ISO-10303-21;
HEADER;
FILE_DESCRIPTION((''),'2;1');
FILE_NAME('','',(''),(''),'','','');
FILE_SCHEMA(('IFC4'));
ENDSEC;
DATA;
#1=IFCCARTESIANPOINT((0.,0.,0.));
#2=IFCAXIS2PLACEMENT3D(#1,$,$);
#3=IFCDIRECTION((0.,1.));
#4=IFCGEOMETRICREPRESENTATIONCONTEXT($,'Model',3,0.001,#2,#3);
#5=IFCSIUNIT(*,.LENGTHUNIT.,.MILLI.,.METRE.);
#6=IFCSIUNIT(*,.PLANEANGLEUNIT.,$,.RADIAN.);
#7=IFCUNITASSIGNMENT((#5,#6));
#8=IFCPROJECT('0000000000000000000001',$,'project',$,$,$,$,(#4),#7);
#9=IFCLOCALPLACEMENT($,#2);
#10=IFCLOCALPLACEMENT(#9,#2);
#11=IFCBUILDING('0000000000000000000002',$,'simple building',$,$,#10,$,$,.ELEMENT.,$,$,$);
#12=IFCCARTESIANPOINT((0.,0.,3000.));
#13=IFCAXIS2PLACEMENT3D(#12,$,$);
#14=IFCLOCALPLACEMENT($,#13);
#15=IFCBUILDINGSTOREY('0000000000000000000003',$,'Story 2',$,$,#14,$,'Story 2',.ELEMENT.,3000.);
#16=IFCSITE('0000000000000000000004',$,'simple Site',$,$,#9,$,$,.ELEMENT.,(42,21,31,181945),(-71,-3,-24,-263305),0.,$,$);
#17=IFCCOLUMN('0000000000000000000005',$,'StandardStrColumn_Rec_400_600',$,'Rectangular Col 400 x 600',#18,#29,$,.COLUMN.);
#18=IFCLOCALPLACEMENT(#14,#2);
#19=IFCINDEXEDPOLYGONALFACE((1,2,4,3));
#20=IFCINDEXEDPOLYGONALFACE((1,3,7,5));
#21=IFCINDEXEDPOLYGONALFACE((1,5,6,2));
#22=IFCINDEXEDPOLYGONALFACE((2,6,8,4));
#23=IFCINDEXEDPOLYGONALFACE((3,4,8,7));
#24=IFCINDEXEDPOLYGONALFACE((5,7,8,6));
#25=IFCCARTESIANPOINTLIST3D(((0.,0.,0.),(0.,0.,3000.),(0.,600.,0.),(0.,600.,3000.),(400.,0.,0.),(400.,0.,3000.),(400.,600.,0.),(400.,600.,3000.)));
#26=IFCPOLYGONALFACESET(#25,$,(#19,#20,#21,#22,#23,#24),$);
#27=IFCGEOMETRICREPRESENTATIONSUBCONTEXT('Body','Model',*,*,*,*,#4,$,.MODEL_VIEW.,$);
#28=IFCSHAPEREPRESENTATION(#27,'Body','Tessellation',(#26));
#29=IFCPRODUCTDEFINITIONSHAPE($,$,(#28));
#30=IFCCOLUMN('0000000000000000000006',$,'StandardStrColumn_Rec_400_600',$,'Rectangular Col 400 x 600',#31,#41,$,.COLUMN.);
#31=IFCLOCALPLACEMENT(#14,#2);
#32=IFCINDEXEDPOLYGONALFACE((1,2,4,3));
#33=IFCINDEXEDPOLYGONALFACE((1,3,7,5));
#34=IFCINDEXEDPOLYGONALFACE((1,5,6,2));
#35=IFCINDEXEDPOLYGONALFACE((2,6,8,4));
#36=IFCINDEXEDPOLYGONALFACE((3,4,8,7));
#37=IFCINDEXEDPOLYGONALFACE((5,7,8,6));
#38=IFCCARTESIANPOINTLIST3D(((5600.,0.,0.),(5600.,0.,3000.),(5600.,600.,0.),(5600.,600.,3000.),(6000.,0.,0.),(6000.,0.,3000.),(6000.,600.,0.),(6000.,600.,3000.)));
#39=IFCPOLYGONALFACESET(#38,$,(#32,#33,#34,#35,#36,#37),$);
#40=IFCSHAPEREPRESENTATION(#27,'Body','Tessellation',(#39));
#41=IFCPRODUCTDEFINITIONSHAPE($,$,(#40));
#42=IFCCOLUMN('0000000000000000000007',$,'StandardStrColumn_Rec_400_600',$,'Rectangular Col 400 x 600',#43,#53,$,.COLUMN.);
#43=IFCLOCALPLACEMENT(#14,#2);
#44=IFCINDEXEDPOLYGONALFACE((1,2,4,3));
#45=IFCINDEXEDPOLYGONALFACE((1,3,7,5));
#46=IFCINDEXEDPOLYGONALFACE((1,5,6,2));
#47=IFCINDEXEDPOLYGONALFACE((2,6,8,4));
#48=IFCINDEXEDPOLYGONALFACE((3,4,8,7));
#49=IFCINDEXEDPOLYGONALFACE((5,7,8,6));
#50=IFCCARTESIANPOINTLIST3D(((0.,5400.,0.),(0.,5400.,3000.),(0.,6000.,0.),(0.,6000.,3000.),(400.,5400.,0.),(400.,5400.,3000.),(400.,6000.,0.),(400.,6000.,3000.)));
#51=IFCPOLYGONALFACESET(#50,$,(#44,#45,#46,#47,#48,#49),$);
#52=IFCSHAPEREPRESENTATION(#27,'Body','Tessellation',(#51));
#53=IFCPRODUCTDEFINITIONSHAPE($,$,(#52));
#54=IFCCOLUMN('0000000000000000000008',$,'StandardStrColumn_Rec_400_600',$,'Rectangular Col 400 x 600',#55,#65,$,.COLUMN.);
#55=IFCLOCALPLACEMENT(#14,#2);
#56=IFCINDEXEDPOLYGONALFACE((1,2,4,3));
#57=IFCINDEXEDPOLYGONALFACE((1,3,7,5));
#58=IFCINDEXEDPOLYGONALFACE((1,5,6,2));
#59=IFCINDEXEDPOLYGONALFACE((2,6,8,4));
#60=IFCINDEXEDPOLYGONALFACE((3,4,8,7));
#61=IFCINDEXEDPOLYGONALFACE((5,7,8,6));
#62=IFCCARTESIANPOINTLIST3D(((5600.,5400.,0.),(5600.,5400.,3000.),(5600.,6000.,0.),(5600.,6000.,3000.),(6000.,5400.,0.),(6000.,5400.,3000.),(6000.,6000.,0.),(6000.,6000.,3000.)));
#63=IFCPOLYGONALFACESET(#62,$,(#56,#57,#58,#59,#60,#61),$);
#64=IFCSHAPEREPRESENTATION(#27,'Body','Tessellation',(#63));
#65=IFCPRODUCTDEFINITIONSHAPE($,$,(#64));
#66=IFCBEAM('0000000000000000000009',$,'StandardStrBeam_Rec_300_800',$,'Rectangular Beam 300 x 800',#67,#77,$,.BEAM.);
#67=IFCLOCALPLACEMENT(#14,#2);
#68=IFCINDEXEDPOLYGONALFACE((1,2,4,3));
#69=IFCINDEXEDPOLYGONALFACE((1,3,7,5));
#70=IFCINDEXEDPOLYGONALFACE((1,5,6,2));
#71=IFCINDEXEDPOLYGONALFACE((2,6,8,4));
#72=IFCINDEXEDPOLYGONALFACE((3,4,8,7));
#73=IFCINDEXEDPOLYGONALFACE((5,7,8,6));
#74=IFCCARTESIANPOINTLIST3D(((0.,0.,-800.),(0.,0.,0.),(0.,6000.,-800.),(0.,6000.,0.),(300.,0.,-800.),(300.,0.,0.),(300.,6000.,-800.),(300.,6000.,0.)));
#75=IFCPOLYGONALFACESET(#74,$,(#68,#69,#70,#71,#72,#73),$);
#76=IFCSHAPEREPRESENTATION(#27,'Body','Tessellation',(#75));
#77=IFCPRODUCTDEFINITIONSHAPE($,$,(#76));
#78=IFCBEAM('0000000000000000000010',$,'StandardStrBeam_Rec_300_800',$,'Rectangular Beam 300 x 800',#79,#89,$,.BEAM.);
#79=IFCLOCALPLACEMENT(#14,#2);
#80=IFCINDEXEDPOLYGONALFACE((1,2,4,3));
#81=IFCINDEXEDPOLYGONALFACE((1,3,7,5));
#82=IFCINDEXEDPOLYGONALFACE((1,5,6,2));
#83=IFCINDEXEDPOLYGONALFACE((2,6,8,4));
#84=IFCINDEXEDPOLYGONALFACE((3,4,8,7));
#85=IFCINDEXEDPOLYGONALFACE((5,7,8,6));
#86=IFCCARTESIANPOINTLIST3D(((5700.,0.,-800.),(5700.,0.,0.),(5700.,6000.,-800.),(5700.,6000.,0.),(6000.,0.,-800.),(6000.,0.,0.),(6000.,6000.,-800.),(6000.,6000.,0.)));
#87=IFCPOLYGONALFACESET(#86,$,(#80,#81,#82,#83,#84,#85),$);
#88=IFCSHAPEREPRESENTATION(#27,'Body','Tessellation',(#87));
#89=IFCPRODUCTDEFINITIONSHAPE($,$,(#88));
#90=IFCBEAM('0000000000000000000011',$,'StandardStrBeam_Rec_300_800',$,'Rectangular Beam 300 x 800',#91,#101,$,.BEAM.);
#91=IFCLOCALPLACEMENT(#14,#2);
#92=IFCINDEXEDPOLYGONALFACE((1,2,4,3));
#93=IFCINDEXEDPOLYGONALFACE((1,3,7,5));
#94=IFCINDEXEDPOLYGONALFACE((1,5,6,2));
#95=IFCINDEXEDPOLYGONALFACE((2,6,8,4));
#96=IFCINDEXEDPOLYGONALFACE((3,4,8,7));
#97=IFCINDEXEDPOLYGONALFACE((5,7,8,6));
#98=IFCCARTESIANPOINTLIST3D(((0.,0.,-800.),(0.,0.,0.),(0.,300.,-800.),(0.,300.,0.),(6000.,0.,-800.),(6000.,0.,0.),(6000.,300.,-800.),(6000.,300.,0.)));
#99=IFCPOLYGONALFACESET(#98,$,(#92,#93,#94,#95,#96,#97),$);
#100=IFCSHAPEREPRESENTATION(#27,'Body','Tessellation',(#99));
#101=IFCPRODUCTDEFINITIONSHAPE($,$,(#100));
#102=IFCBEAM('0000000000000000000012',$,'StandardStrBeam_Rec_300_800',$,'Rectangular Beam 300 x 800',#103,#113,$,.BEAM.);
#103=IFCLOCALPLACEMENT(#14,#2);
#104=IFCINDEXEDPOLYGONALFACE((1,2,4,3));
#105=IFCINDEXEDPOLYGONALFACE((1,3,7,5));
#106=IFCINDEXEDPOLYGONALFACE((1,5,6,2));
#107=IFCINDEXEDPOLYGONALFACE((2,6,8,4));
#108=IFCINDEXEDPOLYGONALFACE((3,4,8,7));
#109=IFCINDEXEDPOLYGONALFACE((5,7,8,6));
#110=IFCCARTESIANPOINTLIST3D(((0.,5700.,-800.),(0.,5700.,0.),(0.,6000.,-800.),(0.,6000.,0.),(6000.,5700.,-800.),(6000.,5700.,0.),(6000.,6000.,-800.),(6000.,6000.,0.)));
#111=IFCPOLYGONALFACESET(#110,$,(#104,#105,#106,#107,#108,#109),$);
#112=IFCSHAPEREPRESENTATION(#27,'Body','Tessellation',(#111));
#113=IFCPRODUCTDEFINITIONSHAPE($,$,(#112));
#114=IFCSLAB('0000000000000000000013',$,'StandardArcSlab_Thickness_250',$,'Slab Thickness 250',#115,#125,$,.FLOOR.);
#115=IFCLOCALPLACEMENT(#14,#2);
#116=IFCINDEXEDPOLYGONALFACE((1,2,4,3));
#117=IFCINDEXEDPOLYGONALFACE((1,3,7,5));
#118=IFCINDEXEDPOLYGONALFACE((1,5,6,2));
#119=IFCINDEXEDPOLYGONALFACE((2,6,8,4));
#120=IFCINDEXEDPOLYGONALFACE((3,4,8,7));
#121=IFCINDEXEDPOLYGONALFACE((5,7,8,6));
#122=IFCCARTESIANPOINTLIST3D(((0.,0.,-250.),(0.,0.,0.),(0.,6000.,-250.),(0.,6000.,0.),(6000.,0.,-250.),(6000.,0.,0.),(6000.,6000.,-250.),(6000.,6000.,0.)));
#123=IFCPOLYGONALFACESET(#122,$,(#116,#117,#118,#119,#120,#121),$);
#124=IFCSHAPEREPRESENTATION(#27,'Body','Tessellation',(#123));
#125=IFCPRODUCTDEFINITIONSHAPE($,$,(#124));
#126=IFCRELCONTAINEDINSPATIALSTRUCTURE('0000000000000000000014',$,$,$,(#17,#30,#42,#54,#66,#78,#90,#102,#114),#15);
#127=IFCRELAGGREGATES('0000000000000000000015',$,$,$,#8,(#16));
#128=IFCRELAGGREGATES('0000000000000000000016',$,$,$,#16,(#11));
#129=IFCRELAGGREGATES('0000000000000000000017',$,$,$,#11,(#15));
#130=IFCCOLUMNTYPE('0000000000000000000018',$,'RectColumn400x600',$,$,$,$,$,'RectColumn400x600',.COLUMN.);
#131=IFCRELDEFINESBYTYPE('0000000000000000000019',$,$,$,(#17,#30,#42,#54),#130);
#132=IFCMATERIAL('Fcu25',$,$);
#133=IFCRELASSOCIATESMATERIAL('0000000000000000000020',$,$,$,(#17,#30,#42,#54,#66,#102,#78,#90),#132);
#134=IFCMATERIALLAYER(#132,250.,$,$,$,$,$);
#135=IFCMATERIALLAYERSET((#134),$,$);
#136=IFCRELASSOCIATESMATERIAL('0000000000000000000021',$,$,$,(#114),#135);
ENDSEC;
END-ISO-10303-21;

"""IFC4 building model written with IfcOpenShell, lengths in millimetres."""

from ifc_helpers import new_model, si_unit, direction, frame, origin, origin_with_axes, origin_2d_with_axis, place, context, subcontext, project, spatial, polyline, rectangle, outline, extrude, material, layer, layer_set, layer_usage, material_profile, profile_set, profile_usage, type_object, element, save


model = new_model("IFC4")

# Units and contexts
model_context = context("Model", 3, precision=0.001, world=origin(), true_north=direction((0.0, 1.0)))
body_context = subcontext(model_context, "Body", "Model", "MODEL_VIEW")
ifc_project = project(units=[si_unit("LENGTHUNIT", "METRE", prefix="MILLI"), si_unit("PLANEANGLEUNIT", "RADIAN")], contexts=[model_context])

# Site, building, storey
site_placement = place(None, origin())
site = spatial("IfcSite", under=ifc_project, at=site_placement, Name="simple Site", CompositionType="ELEMENT", RefLatitude=(42, 21, 31, 181945), RefLongitude=(-71, -3, -24, -263305), RefElevation=0.0)
building_placement = place(site_placement, origin())
building = spatial("IfcBuilding", under=site, at=building_placement, Name="simple building", CompositionType="ELEMENT")
storey_placement = place(None, frame((0.0, 0.0, 3000.0)))
storey = spatial("IfcBuildingStorey", under=building, at=storey_placement, Name="Story 2", LongName="Story 2", CompositionType="ELEMENT", Elevation=3000.0)

# Columns
ifc_material = material(Name="Fcu25")
ifc_material_profile_1 = material_profile(ifc_material, rectangle(XDim=400.0, YDim=600.0, at=origin_2d_with_axis()))
ifc_profile_set_1 = profile_set([ifc_material_profile_1])
ifc_profile_usage_1 = profile_usage(ifc_profile_set_1, cardinal=7)
column_type = type_object("IfcColumnType", Name="RectColumn400x600", ElementType="RectColumn400x600", PredefinedType="COLUMN")
column_1_placement = place(None, frame((200.0, 300.0, 3000.0), z_axis=(0.0, 0.0, 1.0), x_axis=(1.0, 0.0, 0.0)))
element("IfcColumn", 1, at=column_1_placement, inside=storey, type_object=column_type, material=ifc_profile_usage_1, Name="StandardStrColumn_Rec_400_600", ObjectType="Rectangular Col 400 x 600", PredefinedType="COLUMN", context=body_context, shape_type="SweptSolid", body=[
    extrude(rectangle(XDim=400.0, YDim=600.0, at=origin_2d_with_axis()), origin_with_axes(), (0.0, 0.0, 1.0), 3000.0),
])
ifc_profile_usage_2 = profile_usage(ifc_profile_set_1, cardinal=9)
column_2_placement = place(None, frame((5800.0, 300.0, 3000.0), z_axis=(0.0, 0.0, 1.0), x_axis=(1.0, 0.0, 0.0)))
element("IfcColumn", 2, at=column_2_placement, inside=storey, type_object=column_type, material=ifc_profile_usage_2, Name="StandardStrColumn_Rec_400_600", ObjectType="Rectangular Col 400 x 600", PredefinedType="COLUMN", context=body_context, shape_type="SweptSolid", body=[
    extrude(rectangle(XDim=400.0, YDim=600.0, at=origin_2d_with_axis()), origin_with_axes(), (0.0, 0.0, 1.0), 3000.0),
])
ifc_profile_usage_3 = profile_usage(ifc_profile_set_1, cardinal=1)
column_3_placement = place(None, frame((200.0, 5700.0, 3000.0), z_axis=(0.0, 0.0, 1.0), x_axis=(1.0, 0.0, 0.0)))
element("IfcColumn", 3, at=column_3_placement, inside=storey, type_object=column_type, material=ifc_profile_usage_3, Name="StandardStrColumn_Rec_400_600", ObjectType="Rectangular Col 400 x 600", PredefinedType="COLUMN", context=body_context, shape_type="SweptSolid", body=[
    extrude(rectangle(XDim=400.0, YDim=600.0, at=origin_2d_with_axis()), origin_with_axes(), (0.0, 0.0, 1.0), 3000.0),
])
ifc_profile_usage_4 = profile_usage(ifc_profile_set_1, cardinal=3)
column_4_placement = place(None, frame((5800.0, 5700.0, 3000.0), z_axis=(0.0, 0.0, 1.0), x_axis=(1.0, 0.0, 0.0)))
element("IfcColumn", 4, at=column_4_placement, inside=storey, type_object=column_type, material=ifc_profile_usage_4, Name="StandardStrColumn_Rec_400_600", ObjectType="Rectangular Col 400 x 600", PredefinedType="COLUMN", context=body_context, shape_type="SweptSolid", body=[
    extrude(rectangle(XDim=400.0, YDim=600.0, at=origin_2d_with_axis()), origin_with_axes(), (0.0, 0.0, 1.0), 3000.0),
])

# Beams
ifc_material_profile_2 = material_profile(ifc_material, rectangle(XDim=300.0, YDim=800.0, at=origin_2d_with_axis()))
ifc_profile_set_2 = profile_set([ifc_material_profile_2])
ifc_profile_usage_5 = profile_usage(ifc_profile_set_2, cardinal=7)
beam_1_placement = place(None, frame((150.0, 0.0, 2600.0), z_axis=(0.0, 1.0, 0.0), x_axis=(1.0, 0.0, 0.0)))
element("IfcBeam", 5, at=beam_1_placement, inside=storey, material=ifc_profile_usage_5, Name="StandardStrBeam_Rec_300_800", ObjectType="Rectangular Beam 300 x 800", PredefinedType="BEAM", context=body_context, shape_type="SweptSolid", body=[
    extrude(rectangle(XDim=300.0, YDim=800.0, at=origin_2d_with_axis()), origin_with_axes(), (0.0, 0.0, 1.0), 6000.0),
])
ifc_profile_usage_6 = profile_usage(ifc_profile_set_2, cardinal=9)
for number, where, z_axis, x_axis, name in (
    (6, (5850.0, 0.0, 2600.0), (0.0, 1.0, 0.0), (1.0, 0.0, 0.0), "StandardStrBeam_Rec_300_800"),
    (7, (0.0, 150.0, 2600.0), (1.0, 0.0, 0.0), (0.0, -1.0, 0.0), "StandardStrBeam_Rec_300_800"),
):
    element("IfcBeam", number, at=place(None, frame(where, z_axis=z_axis, x_axis=x_axis)), inside=storey, material=ifc_profile_usage_6, Name=name, ObjectType="Rectangular Beam 300 x 800", PredefinedType="BEAM", context=body_context, shape_type="SweptSolid", body=[
        extrude(rectangle(XDim=300.0, YDim=800.0, at=origin_2d_with_axis()), origin_with_axes(), (0.0, 0.0, 1.0), 6000.0),
    ])
beam_2_placement = place(None, frame((0.0, 5850.0, 2600.0), z_axis=(1.0, 0.0, 0.0), x_axis=(0.0, -1.0, 0.0)))
element("IfcBeam", 8, at=beam_2_placement, inside=storey, material=ifc_profile_usage_5, Name="StandardStrBeam_Rec_300_800", ObjectType="Rectangular Beam 300 x 800", PredefinedType="BEAM", context=body_context, shape_type="SweptSolid", body=[
    extrude(rectangle(XDim=300.0, YDim=800.0, at=origin_2d_with_axis()), origin_with_axes(), (0.0, 0.0, 1.0), 6000.0),
])

# Slab
ifc_layer = layer(ifc_material, 250.0)
ifc_layer_set = layer_set([ifc_layer])
ifc_layer_usage = layer_usage(ifc_layer_set, "AXIS3", "POSITIVE", -250.0)
slab_placement = place(None, frame((0.0, 0.0, 2750.0), z_axis=(0.0, 0.0, 1.0), x_axis=(1.0, 0.0, 0.0)))
element("IfcSlab", 9, at=slab_placement, inside=storey, material=ifc_layer_usage, Name="StandardArcSlab_Thickness_250", ObjectType="Slab Thickness 250", PredefinedType="FLOOR", context=body_context, shape_type="SweptSolid", body=[
    extrude(outline(polyline([(0.0, 0.0), (6000.0, 0.0), (6000.0, 6000.0), (0.0, 6000.0), (0.0, 0.0)])), origin_with_axes(), (0.0, 0.0, 1.0), 250.0),
])

save(model, "model.ifc")
